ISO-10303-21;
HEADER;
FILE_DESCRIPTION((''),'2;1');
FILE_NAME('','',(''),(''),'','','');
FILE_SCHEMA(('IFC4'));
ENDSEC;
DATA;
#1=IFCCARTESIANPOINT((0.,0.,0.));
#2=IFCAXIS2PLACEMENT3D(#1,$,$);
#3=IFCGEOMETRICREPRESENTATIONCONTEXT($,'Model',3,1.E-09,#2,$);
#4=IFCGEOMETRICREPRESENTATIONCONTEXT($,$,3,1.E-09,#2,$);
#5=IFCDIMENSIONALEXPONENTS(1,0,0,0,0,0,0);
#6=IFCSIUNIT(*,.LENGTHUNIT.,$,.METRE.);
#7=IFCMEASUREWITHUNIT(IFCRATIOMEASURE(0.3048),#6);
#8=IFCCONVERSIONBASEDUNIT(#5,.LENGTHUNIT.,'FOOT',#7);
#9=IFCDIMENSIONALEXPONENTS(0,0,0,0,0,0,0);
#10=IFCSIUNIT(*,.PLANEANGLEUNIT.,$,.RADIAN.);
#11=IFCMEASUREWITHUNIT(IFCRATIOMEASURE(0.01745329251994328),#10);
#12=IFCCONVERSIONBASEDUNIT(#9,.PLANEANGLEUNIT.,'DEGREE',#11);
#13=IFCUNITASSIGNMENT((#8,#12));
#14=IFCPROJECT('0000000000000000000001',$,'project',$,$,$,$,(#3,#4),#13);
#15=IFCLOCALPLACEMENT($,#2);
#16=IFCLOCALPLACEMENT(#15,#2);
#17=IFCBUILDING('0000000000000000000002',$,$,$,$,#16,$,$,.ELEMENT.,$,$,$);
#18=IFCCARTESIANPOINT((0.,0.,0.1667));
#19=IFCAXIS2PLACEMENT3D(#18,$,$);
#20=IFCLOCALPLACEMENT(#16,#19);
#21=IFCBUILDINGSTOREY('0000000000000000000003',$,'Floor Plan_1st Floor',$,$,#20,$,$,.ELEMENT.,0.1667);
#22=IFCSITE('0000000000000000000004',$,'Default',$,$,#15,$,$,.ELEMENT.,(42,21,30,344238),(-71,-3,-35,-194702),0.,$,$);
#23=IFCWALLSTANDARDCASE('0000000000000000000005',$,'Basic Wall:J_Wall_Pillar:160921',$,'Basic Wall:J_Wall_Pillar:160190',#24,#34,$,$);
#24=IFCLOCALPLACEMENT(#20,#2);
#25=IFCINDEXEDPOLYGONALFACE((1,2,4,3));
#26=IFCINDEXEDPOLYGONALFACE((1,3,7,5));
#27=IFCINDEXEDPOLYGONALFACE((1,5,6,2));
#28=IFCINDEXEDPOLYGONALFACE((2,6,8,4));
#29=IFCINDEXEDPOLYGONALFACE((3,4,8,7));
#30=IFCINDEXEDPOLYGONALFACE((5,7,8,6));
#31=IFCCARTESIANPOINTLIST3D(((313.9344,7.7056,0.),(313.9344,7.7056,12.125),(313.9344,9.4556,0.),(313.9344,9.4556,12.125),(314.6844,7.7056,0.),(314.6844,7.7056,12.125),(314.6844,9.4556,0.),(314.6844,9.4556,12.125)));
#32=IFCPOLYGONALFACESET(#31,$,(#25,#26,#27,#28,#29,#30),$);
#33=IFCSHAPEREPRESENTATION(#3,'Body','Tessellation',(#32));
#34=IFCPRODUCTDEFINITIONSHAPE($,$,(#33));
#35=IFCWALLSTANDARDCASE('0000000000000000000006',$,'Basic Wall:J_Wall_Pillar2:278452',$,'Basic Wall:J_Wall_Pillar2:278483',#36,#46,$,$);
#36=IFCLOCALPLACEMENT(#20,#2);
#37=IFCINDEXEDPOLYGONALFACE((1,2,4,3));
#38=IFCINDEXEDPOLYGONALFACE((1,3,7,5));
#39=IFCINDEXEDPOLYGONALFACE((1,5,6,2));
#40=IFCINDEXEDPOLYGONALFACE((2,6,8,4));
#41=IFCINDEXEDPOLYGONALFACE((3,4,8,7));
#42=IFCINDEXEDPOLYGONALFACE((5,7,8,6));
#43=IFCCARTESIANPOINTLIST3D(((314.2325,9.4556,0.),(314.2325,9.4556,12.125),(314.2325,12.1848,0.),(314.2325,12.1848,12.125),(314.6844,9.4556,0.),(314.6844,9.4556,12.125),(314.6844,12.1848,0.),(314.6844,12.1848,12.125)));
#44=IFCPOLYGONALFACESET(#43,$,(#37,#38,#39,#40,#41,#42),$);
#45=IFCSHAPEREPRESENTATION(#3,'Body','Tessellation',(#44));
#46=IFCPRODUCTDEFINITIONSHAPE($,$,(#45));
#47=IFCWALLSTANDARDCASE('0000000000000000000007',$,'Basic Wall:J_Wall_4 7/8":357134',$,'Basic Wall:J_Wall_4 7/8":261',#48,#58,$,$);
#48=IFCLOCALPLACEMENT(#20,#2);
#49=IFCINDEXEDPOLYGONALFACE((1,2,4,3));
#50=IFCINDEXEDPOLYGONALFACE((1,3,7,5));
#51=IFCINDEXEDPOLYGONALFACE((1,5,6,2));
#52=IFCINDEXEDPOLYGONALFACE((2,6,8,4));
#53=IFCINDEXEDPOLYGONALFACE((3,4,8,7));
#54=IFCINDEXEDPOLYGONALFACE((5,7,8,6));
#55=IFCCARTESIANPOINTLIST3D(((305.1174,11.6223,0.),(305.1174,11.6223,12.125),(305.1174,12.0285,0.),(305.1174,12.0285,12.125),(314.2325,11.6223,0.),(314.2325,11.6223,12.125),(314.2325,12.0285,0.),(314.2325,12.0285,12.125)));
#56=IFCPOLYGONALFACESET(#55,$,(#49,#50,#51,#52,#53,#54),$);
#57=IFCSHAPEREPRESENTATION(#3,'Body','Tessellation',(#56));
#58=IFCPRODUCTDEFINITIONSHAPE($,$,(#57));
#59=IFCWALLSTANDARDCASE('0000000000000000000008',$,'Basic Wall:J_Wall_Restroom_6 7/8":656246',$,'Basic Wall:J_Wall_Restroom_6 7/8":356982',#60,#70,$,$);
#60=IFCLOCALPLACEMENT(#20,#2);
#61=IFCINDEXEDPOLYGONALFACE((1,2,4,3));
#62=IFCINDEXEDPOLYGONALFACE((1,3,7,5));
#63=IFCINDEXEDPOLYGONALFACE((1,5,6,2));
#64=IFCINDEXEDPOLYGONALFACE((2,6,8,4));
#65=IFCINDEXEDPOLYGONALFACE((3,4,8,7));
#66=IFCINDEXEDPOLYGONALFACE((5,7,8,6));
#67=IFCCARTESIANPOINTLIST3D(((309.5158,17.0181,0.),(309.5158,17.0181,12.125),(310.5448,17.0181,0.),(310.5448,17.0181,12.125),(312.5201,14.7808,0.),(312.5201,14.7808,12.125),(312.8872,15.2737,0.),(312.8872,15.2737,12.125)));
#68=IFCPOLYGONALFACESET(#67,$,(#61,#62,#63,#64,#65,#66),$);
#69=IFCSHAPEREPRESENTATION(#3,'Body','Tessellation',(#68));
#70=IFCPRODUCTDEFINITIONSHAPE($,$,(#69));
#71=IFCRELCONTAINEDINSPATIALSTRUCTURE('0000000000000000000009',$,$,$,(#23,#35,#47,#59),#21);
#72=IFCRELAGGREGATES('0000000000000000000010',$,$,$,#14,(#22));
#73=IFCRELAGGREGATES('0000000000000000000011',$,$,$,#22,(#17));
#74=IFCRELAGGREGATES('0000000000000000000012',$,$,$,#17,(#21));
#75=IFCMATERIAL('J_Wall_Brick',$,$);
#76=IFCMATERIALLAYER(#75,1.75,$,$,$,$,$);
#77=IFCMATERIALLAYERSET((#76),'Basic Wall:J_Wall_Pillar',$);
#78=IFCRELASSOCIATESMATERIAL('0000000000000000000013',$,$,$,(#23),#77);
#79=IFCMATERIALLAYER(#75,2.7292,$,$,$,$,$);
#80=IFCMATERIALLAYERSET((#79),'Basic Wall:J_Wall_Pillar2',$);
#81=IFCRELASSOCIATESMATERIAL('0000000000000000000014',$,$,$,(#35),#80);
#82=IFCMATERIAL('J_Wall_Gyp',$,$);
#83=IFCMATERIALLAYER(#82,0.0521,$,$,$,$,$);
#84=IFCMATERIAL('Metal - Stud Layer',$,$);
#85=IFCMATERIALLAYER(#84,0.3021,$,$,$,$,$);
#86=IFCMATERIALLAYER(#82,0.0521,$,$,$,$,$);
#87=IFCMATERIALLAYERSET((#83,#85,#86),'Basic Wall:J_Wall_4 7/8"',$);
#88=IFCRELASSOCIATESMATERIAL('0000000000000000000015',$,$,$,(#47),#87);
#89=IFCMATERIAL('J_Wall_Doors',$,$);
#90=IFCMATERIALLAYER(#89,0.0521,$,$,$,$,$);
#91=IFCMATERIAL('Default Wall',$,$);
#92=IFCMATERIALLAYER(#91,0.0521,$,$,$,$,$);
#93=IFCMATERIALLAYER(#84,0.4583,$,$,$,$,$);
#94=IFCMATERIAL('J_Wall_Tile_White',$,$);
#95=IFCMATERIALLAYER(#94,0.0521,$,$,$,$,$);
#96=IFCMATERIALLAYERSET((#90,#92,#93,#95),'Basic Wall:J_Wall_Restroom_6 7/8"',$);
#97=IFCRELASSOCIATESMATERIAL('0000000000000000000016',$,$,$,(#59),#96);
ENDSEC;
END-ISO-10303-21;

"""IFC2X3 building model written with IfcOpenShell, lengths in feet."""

from ifc_helpers import new_model, entity, si_unit, converted_unit, frame, frame_2d, origin, place, context, project, spatial, polyline, rectangle, outline, extrude, clip, halfspace, material, layer, layer_set, layer_usage, element, save


model = new_model("IFC2X3")

# Units and contexts
model_context = context("Model", 3, precision=1e-09, world=origin())
context_of_model = context(None, 3, precision=1e-09, world=origin())
ifc_project = project(units=[converted_unit("LENGTHUNIT", "FOOT", entity("IfcRatioMeasure", 0.3048), si_unit("LENGTHUNIT", "METRE"), dimensions=[1, 0, 0, 0, 0, 0, 0]), converted_unit("PLANEANGLEUNIT", "DEGREE", entity("IfcRatioMeasure", 0.01745329251994328), si_unit("PLANEANGLEUNIT", "RADIAN"), dimensions=[0, 0, 0, 0, 0, 0, 0])], contexts=[model_context, context_of_model])

# Site, building, storey
site_placement = place(None, origin())
site = spatial("IfcSite", under=ifc_project, at=site_placement, Name="Default", CompositionType="ELEMENT", RefLatitude=(42, 21, 30, 344238), RefLongitude=(-71, -3, -35, -194702), RefElevation=0.0)
building_placement = place(site_placement, origin())
building = spatial("IfcBuilding", under=site, at=building_placement, CompositionType="ELEMENT")
storey_placement = place(building_placement, frame((0.0, 0.0, 0.1667)))
storey = spatial("IfcBuildingStorey", under=building, at=storey_placement, Name="Floor Plan_1st Floor", CompositionType="ELEMENT", Elevation=0.1667)

# Walls
ifc_material_1 = material(Name="J_Wall_Brick")
ifc_layer_1 = layer(ifc_material_1, 1.75)
ifc_layer_set_1 = layer_set([ifc_layer_1], Name="Basic Wall:J_Wall_Pillar")
ifc_layer_usage_1 = layer_usage(ifc_layer_set_1, "AXIS2", "NEGATIVE", 0.875)
wall_1_placement = place(storey_placement, frame((314.6844, 8.5806, 0.0), z_axis=(0.0, 0.0, 1.0), x_axis=(-1.0, 0.0, 0.0)))
element("IfcWallStandardCase", 1, at=wall_1_placement, inside=storey, material=ifc_layer_usage_1, Name="Basic Wall:J_Wall_Pillar:160921", ObjectType="Basic Wall:J_Wall_Pillar:160190", context=model_context, shape_type="Clipping", body=[
    clip(extrude(rectangle(XDim=0.75, YDim=1.75, at=frame_2d((0.375, 0.0), x_axis=(-1.0, 0.0))), origin(), (0.0, 0.0, 1.0), 12.125), halfspace(origin(), True)),
])
ifc_layer_2 = layer(ifc_material_1, 2.7292)
ifc_layer_set_2 = layer_set([ifc_layer_2], Name="Basic Wall:J_Wall_Pillar2")
ifc_layer_usage_2 = layer_usage(ifc_layer_set_2, "AXIS2", "NEGATIVE", 1.3646)
wall_2_placement = place(storey_placement, frame((314.6844, 10.8202, 0.0), z_axis=(0.0, 0.0, 1.0), x_axis=(-1.0, 0.0, 0.0)))
element("IfcWallStandardCase", 2, at=wall_2_placement, inside=storey, material=ifc_layer_usage_2, Name="Basic Wall:J_Wall_Pillar2:278452", ObjectType="Basic Wall:J_Wall_Pillar2:278483", context=model_context, shape_type="Clipping", body=[
    clip(extrude(rectangle(XDim=0.4519, YDim=2.7292, at=frame_2d((0.2259, 0.0), x_axis=(-1.0, 0.0))), origin(), (0.0, 0.0, 1.0), 12.125), halfspace(origin(), True)),
])
ifc_material_2 = material(Name="J_Wall_Gyp")
ifc_layer_3 = layer(ifc_material_2, 0.0521)
ifc_material_3 = material(Name="Metal - Stud Layer")
ifc_layer_4 = layer(ifc_material_3, 0.3021)
ifc_layer_5 = layer(ifc_material_2, 0.0521)
ifc_layer_set_3 = layer_set([ifc_layer_3, ifc_layer_4, ifc_layer_5], Name="Basic Wall:J_Wall_4 7/8\"")
ifc_layer_usage_3 = layer_usage(ifc_layer_set_3, "AXIS2", "NEGATIVE", 0.2031)
wall_3_placement = place(storey_placement, frame((305.1174, 11.8254, 0.0)))
element("IfcWallStandardCase", 3, at=wall_3_placement, inside=storey, material=ifc_layer_usage_3, Name="Basic Wall:J_Wall_4 7/8\":357134", ObjectType="Basic Wall:J_Wall_4 7/8\":261", context=model_context, shape_type="Clipping", body=[
    clip(extrude(rectangle(XDim=9.1151, YDim=0.4062, at=frame_2d((4.5575, 0.0), x_axis=(-1.0, 0.0))), origin(), (0.0, 0.0, 1.0), 12.125), halfspace(origin(), True)),
])
ifc_material_4 = material(Name="J_Wall_Doors")
ifc_layer_6 = layer(ifc_material_4, 0.0521)
ifc_material_5 = material(Name="Default Wall")
ifc_layer_7 = layer(ifc_material_5, 0.0521)
ifc_layer_8 = layer(ifc_material_3, 0.4583)
ifc_material_6 = material(Name="J_Wall_Tile_White")
ifc_layer_9 = layer(ifc_material_6, 0.0521)
ifc_layer_set_4 = layer_set([ifc_layer_6, ifc_layer_7, ifc_layer_8, ifc_layer_9], Name="Basic Wall:J_Wall_Restroom_6 7/8\"")
ifc_layer_usage_4 = layer_usage(ifc_layer_set_4, "AXIS2", "POSITIVE", -0.3073)
wall_4_placement = place(storey_placement, frame((312.7037, 15.0272, 0.0), z_axis=(0.0, 0.0, 1.0), x_axis=(-0.802039, 0.597272, 0.0)))
element("IfcWallStandardCase", 4, at=wall_4_placement, inside=storey, material=ifc_layer_usage_4, Name="Basic Wall:J_Wall_Restroom_6 7/8\":656246", ObjectType="Basic Wall:J_Wall_Restroom_6 7/8\":356982", context=model_context, shape_type="Clipping", body=[
    clip(extrude(outline(polyline([(2.9206, -0.3073), (3.7459, 0.3073), (0.0, 0.3073), (0.0, -0.3073), (2.9206, -0.3073)])), origin(), (0.0, 0.0, 1.0), 12.125), halfspace(origin(), True)),
])

save(model, "model.ifc")
